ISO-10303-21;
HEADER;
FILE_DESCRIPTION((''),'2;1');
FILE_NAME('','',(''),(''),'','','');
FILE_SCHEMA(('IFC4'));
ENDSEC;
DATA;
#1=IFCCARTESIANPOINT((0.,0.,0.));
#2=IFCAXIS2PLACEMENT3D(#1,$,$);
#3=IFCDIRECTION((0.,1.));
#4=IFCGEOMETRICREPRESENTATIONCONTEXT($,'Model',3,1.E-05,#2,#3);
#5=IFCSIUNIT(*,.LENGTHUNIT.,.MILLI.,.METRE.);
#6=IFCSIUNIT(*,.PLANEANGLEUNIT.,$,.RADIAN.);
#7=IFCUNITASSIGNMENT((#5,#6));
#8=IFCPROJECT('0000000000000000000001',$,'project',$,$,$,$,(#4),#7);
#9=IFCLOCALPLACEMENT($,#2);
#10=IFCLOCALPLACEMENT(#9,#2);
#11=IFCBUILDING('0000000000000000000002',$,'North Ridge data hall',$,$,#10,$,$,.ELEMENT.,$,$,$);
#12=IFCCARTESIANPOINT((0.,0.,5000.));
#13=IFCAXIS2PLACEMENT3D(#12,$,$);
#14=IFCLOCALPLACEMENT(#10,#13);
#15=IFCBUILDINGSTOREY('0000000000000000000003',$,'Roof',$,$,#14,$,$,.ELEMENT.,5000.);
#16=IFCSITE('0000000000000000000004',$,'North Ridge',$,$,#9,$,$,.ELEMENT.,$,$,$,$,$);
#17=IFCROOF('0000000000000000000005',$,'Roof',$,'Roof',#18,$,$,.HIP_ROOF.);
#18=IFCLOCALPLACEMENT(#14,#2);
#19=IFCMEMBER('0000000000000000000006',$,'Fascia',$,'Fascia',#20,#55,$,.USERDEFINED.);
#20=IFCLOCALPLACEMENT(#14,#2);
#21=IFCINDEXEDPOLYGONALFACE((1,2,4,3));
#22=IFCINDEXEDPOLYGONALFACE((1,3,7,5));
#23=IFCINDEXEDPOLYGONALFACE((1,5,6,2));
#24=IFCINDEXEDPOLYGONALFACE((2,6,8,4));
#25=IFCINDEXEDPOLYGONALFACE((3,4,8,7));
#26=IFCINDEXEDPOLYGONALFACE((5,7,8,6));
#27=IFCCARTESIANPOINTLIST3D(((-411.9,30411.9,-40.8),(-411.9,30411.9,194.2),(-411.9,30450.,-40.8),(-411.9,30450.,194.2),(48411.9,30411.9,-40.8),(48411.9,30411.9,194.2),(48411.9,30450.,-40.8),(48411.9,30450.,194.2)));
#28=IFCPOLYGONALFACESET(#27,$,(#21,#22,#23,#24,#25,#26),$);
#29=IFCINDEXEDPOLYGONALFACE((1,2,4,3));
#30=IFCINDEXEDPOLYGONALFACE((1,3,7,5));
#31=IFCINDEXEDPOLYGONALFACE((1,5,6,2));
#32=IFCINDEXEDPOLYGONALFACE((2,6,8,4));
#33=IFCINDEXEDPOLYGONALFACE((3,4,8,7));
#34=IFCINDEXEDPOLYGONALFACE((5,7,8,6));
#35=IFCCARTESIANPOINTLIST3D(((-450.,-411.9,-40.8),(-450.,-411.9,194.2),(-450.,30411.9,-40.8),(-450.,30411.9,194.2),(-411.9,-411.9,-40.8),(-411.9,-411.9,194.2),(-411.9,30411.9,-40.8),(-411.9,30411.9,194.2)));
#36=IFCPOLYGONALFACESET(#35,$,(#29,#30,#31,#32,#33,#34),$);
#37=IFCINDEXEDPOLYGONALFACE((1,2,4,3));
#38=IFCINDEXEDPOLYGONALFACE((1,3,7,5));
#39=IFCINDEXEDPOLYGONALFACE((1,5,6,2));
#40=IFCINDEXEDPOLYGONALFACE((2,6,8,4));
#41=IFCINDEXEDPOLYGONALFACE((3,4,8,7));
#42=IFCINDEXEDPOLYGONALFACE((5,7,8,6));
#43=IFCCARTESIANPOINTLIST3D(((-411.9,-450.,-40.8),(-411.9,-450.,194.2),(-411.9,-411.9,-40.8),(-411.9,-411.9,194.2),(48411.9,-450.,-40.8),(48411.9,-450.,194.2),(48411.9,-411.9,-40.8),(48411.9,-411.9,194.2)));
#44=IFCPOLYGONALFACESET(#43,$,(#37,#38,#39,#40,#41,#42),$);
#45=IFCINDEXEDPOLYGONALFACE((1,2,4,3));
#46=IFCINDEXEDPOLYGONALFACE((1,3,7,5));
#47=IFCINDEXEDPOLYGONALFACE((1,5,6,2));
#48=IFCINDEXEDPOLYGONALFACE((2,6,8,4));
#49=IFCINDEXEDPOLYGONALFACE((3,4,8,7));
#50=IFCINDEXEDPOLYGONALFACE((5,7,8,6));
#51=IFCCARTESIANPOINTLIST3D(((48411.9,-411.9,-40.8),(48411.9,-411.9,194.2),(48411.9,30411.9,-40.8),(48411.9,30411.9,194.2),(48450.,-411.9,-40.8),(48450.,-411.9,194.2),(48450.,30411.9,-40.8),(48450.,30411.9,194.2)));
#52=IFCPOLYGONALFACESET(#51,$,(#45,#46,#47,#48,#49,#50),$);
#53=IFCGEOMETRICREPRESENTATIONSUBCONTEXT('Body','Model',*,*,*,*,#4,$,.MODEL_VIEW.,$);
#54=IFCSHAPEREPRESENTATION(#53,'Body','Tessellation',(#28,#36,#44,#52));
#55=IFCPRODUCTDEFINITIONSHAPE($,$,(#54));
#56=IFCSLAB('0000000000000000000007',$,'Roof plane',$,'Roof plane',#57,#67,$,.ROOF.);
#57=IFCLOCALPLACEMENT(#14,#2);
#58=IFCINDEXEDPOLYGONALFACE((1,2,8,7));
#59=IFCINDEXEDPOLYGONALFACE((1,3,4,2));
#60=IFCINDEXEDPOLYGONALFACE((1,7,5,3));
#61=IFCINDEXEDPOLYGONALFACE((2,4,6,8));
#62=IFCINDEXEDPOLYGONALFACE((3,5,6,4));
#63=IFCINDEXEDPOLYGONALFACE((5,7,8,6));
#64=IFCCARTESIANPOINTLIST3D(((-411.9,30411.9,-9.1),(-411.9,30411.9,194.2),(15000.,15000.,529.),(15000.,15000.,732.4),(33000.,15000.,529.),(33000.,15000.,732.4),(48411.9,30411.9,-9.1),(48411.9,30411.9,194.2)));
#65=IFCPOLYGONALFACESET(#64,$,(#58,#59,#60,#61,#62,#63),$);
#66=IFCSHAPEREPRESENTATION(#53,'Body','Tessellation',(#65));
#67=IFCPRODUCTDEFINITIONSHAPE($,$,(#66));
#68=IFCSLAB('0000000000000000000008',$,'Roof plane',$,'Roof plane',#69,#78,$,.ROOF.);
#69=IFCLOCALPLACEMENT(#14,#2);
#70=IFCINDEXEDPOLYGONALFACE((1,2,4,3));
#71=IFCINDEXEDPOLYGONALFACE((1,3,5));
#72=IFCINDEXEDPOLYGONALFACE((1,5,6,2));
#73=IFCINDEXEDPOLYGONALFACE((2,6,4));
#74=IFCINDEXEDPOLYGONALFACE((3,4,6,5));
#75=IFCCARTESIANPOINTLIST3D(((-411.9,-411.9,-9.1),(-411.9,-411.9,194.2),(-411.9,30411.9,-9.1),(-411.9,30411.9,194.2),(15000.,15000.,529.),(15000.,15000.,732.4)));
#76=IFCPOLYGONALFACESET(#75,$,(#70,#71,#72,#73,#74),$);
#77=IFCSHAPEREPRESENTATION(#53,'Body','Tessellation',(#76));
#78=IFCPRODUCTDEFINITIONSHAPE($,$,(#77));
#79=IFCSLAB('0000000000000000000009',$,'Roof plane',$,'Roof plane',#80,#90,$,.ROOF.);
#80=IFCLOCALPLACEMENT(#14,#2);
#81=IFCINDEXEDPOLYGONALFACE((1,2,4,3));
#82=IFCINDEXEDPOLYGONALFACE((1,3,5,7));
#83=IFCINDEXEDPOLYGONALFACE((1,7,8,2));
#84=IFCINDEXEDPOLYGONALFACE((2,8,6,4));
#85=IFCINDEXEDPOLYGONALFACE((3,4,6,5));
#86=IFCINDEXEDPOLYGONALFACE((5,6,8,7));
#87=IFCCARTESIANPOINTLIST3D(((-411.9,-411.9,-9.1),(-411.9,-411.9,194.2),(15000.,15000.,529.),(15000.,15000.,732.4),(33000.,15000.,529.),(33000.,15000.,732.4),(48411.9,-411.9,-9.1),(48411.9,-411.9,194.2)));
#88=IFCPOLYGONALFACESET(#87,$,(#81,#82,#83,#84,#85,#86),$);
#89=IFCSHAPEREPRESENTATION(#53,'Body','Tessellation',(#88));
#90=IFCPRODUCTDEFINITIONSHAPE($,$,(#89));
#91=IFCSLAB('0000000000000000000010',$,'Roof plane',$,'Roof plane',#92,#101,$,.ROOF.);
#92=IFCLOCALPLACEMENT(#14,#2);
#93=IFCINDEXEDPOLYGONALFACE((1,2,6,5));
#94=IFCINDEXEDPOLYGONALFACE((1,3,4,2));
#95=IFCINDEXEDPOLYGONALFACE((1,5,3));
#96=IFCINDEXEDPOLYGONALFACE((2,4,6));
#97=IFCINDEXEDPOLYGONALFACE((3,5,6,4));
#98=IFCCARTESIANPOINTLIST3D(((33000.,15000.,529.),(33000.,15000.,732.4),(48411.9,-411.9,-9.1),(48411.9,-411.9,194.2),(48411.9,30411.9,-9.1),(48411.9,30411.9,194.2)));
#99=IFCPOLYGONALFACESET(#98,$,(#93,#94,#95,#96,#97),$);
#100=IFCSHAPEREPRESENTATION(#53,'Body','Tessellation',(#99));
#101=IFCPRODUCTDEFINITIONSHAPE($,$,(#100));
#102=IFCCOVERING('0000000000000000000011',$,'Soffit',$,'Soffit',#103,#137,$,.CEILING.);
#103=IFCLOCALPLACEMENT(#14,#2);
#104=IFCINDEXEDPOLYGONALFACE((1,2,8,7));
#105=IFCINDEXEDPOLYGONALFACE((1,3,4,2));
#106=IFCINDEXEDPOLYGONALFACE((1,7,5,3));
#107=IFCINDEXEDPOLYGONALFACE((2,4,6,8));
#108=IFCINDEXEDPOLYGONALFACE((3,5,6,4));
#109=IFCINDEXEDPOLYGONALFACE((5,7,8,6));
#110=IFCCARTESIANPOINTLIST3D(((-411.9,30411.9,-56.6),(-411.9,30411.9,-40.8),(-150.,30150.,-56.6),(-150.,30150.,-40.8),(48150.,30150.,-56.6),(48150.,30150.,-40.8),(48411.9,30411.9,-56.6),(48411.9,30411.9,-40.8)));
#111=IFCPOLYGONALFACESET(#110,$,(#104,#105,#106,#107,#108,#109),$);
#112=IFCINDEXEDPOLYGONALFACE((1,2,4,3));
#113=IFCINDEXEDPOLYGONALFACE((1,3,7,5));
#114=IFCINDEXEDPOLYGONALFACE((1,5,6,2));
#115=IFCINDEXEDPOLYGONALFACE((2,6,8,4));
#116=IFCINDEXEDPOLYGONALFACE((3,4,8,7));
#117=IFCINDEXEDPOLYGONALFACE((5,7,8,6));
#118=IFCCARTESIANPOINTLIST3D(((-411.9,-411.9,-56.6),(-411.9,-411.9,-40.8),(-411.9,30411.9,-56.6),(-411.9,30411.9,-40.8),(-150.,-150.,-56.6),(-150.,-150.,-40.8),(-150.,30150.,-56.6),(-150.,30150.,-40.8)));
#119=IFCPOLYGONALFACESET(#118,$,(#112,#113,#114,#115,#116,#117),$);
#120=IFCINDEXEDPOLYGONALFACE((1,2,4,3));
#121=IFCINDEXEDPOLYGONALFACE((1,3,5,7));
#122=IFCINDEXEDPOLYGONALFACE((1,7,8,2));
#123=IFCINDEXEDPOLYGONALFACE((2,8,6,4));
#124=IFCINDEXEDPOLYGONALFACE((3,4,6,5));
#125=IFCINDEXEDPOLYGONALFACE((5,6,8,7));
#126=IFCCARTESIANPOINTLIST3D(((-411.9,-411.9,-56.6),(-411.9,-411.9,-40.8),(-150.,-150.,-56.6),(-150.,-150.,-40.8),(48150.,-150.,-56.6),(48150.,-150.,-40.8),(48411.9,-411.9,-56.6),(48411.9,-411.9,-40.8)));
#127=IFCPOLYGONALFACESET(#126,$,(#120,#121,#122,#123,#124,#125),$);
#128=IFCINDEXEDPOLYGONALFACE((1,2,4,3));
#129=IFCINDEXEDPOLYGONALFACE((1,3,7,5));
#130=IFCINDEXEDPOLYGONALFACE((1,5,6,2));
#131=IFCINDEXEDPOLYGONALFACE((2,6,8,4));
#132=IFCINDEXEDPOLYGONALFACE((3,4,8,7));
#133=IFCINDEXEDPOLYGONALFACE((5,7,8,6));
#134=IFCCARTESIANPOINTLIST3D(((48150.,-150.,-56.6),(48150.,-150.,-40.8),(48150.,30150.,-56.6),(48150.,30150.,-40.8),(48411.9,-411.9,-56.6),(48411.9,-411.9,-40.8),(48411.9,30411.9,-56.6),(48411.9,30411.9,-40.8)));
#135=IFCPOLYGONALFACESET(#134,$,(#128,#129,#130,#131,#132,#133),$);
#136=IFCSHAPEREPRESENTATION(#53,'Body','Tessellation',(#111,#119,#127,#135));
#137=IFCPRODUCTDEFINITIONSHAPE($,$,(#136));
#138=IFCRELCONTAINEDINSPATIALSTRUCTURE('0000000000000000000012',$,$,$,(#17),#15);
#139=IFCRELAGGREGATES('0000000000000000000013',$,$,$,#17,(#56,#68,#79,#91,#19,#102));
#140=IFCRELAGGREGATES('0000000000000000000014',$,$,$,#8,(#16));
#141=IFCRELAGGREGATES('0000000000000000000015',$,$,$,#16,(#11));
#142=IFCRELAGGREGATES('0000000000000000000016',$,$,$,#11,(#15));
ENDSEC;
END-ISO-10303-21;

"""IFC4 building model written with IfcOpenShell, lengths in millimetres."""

from ifc_helpers import new_model, si_unit, direction, frame, origin, origin_with_axes, place, context, subcontext, project, spatial, polyline, outline, extrude, element, aggregate, save


model = new_model("IFC4")

# Units and contexts
model_context = context("Model", 3, precision=1e-05, world=origin(), true_north=direction((0.0, 1.0)))
body_context = subcontext(model_context, "Body", "Model", "MODEL_VIEW")
ifc_project = project(units=[si_unit("LENGTHUNIT", "METRE", prefix="MILLI"), si_unit("PLANEANGLEUNIT", "RADIAN")], contexts=[model_context])

# Site, building, storey
site_placement = place(None, origin())
site = spatial("IfcSite", under=ifc_project, at=site_placement, Name="North Ridge", CompositionType="ELEMENT")
building_placement = place(site_placement, origin())
building = spatial("IfcBuilding", under=site, at=building_placement, Name="North Ridge data hall", CompositionType="ELEMENT")
storey_placement = place(building_placement, frame((0.0, 0.0, 5000.0)))
storey = spatial("IfcBuildingStorey", under=building, at=storey_placement, Name="Roof", CompositionType="ELEMENT", Elevation=5000.0)

# Roof, member, slabs, covering
roof_placement = place(storey_placement, origin_with_axes())
roof = element("IfcRoof", 1, at=roof_placement, inside=storey, Name="Roof", ObjectType="Roof", PredefinedType="HIP_ROOF")
member_placement = place(storey_placement, origin_with_axes())
member = element("IfcMember", 2, at=member_placement, Name="Fascia", ObjectType="Fascia", PredefinedType="USERDEFINED", context=body_context, shape_type="SweptSolid", body=[
    extrude(outline(polyline([(0.0, -234.9), (48823.8, -234.9), (48823.8, 0.0), (0.0, 0.0), (0.0, -234.9)])), frame((48411.9, 30411.9, 194.2), z_axis=(0.0, 1.0, 0.0), x_axis=(-1.0, 0.0, 0.0)), (0.0, 0.0, 1.0), 38.1),
    extrude(outline(polyline([(0.0, -234.9), (30823.8, -234.9), (30823.8, 0.0), (0.0, 0.0), (0.0, -234.9)])), frame((-411.9, 30411.9, 194.2), z_axis=(-1.0, 0.0, 0.0), x_axis=(0.0, -1.0, 0.0)), (0.0, 0.0, 1.0), 38.1),
    extrude(outline(polyline([(0.0, -234.9), (48823.8, -234.9), (48823.8, 0.0), (0.0, 0.0), (0.0, -234.9)])), frame((-411.9, -411.9, 194.2), z_axis=(0.0, -1.0, 0.0), x_axis=(1.0, 0.0, 0.0)), (0.0, 0.0, 1.0), 38.1),
    extrude(outline(polyline([(0.0, -234.9), (30823.8, -234.9), (30823.8, 0.0), (0.0, 0.0), (0.0, -234.9)])), frame((48411.9, -411.9, 194.2), z_axis=(1.0, 0.0, 0.0), x_axis=(0.0, 1.0, 0.0)), (0.0, 0.0, 1.0), 38.1),
])
slab_1_placement = place(storey_placement, origin_with_axes())
slab_1 = element("IfcSlab", 3, at=slab_1_placement, Name="Roof plane", ObjectType="Roof plane", PredefinedType="ROOF", context=body_context, shape_type="SweptSolid", body=[
    extrude(outline(polyline([(-48411.9, 0.0), (411.9, 0.0), (-15000.0, 15421.3), (-33000.0, 15421.3), (-48411.9, 0.0)])), frame((0.0, 30411.9, -9.1), z_axis=(0.0, 0.034899, 0.999391), x_axis=(-1.0, 0.0, 0.0)), (0.0, 0.034899, 0.999391), 203.3),
])
slab_2_placement = place(storey_placement, origin_with_axes())
slab_2 = element("IfcSlab", 4, at=slab_2_placement, Name="Roof plane", ObjectType="Roof plane", PredefinedType="ROOF", context=body_context, shape_type="SweptSolid", body=[
    extrude(outline(polyline([(-30411.9, 0.0), (411.9, 0.0), (-15000.0, 15421.3), (-30411.9, 0.0)])), frame((-411.9, 0.0, -9.1), z_axis=(-0.034899, 0.0, 0.999391), x_axis=(0.0, -1.0, 0.0)), (0.0, 0.034899, 0.999391), 203.3),
])
slab_3_placement = place(storey_placement, origin_with_axes())
slab_3 = element("IfcSlab", 5, at=slab_3_placement, Name="Roof plane", ObjectType="Roof plane", PredefinedType="ROOF", context=body_context, shape_type="SweptSolid", body=[
    extrude(outline(polyline([(-411.9, 0.0), (48411.9, 0.0), (33000.0, 15421.3), (15000.0, 15421.3), (-411.9, 0.0)])), frame((0.0, -411.9, -9.1), z_axis=(0.0, -0.034899, 0.999391), x_axis=(1.0, 0.0, 0.0)), (0.0, 0.034899, 0.999391), 203.3),
])
slab_4_placement = place(storey_placement, origin_with_axes())
slab_4 = element("IfcSlab", 6, at=slab_4_placement, Name="Roof plane", ObjectType="Roof plane", PredefinedType="ROOF", context=body_context, shape_type="SweptSolid", body=[
    extrude(outline(polyline([(-411.9, 0.0), (30411.9, 0.0), (15000.0, 15421.3), (-411.9, 0.0)])), frame((48411.9, 0.0, -9.1), z_axis=(0.034899, 0.0, 0.999391), x_axis=(0.0, 1.0, 0.0)), (0.0, 0.034899, 0.999391), 203.3),
])
covering_placement = place(storey_placement, origin_with_axes())
covering = element("IfcCovering", 7, at=covering_placement, Name="Soffit", ObjectType="Soffit", PredefinedType="CEILING", context=body_context, shape_type="SweptSolid", body=[
    extrude(outline(polyline([(48150.0, 30150.0), (-150.0, 30150.0), (-411.9, 30411.9), (48411.9, 30411.9), (48150.0, 30150.0)])), frame((0.0, 0.0, -56.6), z_axis=(0.0, 0.0, 1.0), x_axis=(1.0, 0.0, 0.0)), (0.0, 0.0, 1.0), 15.9),
    extrude(outline(polyline([(-150.0, 30150.0), (-150.0, -150.0), (-411.9, -411.9), (-411.9, 30411.9), (-150.0, 30150.0)])), frame((0.0, 0.0, -56.6), z_axis=(0.0, 0.0, 1.0), x_axis=(1.0, 0.0, 0.0)), (0.0, 0.0, 1.0), 15.9),
    extrude(outline(polyline([(-150.0, -150.0), (48150.0, -150.0), (48411.9, -411.9), (-411.9, -411.9), (-150.0, -150.0)])), frame((0.0, 0.0, -56.6), z_axis=(0.0, 0.0, 1.0), x_axis=(1.0, 0.0, 0.0)), (0.0, 0.0, 1.0), 15.9),
    extrude(outline(polyline([(48150.0, -150.0), (48150.0, 30150.0), (48411.9, 30411.9), (48411.9, -411.9), (48150.0, -150.0)])), frame((0.0, 0.0, -56.6), z_axis=(0.0, 0.0, 1.0), x_axis=(1.0, 0.0, 0.0)), (0.0, 0.0, 1.0), 15.9),
])
aggregate(roof, [slab_1, slab_2, slab_3, slab_4, member, covering])

save(model, "model.ifc")
